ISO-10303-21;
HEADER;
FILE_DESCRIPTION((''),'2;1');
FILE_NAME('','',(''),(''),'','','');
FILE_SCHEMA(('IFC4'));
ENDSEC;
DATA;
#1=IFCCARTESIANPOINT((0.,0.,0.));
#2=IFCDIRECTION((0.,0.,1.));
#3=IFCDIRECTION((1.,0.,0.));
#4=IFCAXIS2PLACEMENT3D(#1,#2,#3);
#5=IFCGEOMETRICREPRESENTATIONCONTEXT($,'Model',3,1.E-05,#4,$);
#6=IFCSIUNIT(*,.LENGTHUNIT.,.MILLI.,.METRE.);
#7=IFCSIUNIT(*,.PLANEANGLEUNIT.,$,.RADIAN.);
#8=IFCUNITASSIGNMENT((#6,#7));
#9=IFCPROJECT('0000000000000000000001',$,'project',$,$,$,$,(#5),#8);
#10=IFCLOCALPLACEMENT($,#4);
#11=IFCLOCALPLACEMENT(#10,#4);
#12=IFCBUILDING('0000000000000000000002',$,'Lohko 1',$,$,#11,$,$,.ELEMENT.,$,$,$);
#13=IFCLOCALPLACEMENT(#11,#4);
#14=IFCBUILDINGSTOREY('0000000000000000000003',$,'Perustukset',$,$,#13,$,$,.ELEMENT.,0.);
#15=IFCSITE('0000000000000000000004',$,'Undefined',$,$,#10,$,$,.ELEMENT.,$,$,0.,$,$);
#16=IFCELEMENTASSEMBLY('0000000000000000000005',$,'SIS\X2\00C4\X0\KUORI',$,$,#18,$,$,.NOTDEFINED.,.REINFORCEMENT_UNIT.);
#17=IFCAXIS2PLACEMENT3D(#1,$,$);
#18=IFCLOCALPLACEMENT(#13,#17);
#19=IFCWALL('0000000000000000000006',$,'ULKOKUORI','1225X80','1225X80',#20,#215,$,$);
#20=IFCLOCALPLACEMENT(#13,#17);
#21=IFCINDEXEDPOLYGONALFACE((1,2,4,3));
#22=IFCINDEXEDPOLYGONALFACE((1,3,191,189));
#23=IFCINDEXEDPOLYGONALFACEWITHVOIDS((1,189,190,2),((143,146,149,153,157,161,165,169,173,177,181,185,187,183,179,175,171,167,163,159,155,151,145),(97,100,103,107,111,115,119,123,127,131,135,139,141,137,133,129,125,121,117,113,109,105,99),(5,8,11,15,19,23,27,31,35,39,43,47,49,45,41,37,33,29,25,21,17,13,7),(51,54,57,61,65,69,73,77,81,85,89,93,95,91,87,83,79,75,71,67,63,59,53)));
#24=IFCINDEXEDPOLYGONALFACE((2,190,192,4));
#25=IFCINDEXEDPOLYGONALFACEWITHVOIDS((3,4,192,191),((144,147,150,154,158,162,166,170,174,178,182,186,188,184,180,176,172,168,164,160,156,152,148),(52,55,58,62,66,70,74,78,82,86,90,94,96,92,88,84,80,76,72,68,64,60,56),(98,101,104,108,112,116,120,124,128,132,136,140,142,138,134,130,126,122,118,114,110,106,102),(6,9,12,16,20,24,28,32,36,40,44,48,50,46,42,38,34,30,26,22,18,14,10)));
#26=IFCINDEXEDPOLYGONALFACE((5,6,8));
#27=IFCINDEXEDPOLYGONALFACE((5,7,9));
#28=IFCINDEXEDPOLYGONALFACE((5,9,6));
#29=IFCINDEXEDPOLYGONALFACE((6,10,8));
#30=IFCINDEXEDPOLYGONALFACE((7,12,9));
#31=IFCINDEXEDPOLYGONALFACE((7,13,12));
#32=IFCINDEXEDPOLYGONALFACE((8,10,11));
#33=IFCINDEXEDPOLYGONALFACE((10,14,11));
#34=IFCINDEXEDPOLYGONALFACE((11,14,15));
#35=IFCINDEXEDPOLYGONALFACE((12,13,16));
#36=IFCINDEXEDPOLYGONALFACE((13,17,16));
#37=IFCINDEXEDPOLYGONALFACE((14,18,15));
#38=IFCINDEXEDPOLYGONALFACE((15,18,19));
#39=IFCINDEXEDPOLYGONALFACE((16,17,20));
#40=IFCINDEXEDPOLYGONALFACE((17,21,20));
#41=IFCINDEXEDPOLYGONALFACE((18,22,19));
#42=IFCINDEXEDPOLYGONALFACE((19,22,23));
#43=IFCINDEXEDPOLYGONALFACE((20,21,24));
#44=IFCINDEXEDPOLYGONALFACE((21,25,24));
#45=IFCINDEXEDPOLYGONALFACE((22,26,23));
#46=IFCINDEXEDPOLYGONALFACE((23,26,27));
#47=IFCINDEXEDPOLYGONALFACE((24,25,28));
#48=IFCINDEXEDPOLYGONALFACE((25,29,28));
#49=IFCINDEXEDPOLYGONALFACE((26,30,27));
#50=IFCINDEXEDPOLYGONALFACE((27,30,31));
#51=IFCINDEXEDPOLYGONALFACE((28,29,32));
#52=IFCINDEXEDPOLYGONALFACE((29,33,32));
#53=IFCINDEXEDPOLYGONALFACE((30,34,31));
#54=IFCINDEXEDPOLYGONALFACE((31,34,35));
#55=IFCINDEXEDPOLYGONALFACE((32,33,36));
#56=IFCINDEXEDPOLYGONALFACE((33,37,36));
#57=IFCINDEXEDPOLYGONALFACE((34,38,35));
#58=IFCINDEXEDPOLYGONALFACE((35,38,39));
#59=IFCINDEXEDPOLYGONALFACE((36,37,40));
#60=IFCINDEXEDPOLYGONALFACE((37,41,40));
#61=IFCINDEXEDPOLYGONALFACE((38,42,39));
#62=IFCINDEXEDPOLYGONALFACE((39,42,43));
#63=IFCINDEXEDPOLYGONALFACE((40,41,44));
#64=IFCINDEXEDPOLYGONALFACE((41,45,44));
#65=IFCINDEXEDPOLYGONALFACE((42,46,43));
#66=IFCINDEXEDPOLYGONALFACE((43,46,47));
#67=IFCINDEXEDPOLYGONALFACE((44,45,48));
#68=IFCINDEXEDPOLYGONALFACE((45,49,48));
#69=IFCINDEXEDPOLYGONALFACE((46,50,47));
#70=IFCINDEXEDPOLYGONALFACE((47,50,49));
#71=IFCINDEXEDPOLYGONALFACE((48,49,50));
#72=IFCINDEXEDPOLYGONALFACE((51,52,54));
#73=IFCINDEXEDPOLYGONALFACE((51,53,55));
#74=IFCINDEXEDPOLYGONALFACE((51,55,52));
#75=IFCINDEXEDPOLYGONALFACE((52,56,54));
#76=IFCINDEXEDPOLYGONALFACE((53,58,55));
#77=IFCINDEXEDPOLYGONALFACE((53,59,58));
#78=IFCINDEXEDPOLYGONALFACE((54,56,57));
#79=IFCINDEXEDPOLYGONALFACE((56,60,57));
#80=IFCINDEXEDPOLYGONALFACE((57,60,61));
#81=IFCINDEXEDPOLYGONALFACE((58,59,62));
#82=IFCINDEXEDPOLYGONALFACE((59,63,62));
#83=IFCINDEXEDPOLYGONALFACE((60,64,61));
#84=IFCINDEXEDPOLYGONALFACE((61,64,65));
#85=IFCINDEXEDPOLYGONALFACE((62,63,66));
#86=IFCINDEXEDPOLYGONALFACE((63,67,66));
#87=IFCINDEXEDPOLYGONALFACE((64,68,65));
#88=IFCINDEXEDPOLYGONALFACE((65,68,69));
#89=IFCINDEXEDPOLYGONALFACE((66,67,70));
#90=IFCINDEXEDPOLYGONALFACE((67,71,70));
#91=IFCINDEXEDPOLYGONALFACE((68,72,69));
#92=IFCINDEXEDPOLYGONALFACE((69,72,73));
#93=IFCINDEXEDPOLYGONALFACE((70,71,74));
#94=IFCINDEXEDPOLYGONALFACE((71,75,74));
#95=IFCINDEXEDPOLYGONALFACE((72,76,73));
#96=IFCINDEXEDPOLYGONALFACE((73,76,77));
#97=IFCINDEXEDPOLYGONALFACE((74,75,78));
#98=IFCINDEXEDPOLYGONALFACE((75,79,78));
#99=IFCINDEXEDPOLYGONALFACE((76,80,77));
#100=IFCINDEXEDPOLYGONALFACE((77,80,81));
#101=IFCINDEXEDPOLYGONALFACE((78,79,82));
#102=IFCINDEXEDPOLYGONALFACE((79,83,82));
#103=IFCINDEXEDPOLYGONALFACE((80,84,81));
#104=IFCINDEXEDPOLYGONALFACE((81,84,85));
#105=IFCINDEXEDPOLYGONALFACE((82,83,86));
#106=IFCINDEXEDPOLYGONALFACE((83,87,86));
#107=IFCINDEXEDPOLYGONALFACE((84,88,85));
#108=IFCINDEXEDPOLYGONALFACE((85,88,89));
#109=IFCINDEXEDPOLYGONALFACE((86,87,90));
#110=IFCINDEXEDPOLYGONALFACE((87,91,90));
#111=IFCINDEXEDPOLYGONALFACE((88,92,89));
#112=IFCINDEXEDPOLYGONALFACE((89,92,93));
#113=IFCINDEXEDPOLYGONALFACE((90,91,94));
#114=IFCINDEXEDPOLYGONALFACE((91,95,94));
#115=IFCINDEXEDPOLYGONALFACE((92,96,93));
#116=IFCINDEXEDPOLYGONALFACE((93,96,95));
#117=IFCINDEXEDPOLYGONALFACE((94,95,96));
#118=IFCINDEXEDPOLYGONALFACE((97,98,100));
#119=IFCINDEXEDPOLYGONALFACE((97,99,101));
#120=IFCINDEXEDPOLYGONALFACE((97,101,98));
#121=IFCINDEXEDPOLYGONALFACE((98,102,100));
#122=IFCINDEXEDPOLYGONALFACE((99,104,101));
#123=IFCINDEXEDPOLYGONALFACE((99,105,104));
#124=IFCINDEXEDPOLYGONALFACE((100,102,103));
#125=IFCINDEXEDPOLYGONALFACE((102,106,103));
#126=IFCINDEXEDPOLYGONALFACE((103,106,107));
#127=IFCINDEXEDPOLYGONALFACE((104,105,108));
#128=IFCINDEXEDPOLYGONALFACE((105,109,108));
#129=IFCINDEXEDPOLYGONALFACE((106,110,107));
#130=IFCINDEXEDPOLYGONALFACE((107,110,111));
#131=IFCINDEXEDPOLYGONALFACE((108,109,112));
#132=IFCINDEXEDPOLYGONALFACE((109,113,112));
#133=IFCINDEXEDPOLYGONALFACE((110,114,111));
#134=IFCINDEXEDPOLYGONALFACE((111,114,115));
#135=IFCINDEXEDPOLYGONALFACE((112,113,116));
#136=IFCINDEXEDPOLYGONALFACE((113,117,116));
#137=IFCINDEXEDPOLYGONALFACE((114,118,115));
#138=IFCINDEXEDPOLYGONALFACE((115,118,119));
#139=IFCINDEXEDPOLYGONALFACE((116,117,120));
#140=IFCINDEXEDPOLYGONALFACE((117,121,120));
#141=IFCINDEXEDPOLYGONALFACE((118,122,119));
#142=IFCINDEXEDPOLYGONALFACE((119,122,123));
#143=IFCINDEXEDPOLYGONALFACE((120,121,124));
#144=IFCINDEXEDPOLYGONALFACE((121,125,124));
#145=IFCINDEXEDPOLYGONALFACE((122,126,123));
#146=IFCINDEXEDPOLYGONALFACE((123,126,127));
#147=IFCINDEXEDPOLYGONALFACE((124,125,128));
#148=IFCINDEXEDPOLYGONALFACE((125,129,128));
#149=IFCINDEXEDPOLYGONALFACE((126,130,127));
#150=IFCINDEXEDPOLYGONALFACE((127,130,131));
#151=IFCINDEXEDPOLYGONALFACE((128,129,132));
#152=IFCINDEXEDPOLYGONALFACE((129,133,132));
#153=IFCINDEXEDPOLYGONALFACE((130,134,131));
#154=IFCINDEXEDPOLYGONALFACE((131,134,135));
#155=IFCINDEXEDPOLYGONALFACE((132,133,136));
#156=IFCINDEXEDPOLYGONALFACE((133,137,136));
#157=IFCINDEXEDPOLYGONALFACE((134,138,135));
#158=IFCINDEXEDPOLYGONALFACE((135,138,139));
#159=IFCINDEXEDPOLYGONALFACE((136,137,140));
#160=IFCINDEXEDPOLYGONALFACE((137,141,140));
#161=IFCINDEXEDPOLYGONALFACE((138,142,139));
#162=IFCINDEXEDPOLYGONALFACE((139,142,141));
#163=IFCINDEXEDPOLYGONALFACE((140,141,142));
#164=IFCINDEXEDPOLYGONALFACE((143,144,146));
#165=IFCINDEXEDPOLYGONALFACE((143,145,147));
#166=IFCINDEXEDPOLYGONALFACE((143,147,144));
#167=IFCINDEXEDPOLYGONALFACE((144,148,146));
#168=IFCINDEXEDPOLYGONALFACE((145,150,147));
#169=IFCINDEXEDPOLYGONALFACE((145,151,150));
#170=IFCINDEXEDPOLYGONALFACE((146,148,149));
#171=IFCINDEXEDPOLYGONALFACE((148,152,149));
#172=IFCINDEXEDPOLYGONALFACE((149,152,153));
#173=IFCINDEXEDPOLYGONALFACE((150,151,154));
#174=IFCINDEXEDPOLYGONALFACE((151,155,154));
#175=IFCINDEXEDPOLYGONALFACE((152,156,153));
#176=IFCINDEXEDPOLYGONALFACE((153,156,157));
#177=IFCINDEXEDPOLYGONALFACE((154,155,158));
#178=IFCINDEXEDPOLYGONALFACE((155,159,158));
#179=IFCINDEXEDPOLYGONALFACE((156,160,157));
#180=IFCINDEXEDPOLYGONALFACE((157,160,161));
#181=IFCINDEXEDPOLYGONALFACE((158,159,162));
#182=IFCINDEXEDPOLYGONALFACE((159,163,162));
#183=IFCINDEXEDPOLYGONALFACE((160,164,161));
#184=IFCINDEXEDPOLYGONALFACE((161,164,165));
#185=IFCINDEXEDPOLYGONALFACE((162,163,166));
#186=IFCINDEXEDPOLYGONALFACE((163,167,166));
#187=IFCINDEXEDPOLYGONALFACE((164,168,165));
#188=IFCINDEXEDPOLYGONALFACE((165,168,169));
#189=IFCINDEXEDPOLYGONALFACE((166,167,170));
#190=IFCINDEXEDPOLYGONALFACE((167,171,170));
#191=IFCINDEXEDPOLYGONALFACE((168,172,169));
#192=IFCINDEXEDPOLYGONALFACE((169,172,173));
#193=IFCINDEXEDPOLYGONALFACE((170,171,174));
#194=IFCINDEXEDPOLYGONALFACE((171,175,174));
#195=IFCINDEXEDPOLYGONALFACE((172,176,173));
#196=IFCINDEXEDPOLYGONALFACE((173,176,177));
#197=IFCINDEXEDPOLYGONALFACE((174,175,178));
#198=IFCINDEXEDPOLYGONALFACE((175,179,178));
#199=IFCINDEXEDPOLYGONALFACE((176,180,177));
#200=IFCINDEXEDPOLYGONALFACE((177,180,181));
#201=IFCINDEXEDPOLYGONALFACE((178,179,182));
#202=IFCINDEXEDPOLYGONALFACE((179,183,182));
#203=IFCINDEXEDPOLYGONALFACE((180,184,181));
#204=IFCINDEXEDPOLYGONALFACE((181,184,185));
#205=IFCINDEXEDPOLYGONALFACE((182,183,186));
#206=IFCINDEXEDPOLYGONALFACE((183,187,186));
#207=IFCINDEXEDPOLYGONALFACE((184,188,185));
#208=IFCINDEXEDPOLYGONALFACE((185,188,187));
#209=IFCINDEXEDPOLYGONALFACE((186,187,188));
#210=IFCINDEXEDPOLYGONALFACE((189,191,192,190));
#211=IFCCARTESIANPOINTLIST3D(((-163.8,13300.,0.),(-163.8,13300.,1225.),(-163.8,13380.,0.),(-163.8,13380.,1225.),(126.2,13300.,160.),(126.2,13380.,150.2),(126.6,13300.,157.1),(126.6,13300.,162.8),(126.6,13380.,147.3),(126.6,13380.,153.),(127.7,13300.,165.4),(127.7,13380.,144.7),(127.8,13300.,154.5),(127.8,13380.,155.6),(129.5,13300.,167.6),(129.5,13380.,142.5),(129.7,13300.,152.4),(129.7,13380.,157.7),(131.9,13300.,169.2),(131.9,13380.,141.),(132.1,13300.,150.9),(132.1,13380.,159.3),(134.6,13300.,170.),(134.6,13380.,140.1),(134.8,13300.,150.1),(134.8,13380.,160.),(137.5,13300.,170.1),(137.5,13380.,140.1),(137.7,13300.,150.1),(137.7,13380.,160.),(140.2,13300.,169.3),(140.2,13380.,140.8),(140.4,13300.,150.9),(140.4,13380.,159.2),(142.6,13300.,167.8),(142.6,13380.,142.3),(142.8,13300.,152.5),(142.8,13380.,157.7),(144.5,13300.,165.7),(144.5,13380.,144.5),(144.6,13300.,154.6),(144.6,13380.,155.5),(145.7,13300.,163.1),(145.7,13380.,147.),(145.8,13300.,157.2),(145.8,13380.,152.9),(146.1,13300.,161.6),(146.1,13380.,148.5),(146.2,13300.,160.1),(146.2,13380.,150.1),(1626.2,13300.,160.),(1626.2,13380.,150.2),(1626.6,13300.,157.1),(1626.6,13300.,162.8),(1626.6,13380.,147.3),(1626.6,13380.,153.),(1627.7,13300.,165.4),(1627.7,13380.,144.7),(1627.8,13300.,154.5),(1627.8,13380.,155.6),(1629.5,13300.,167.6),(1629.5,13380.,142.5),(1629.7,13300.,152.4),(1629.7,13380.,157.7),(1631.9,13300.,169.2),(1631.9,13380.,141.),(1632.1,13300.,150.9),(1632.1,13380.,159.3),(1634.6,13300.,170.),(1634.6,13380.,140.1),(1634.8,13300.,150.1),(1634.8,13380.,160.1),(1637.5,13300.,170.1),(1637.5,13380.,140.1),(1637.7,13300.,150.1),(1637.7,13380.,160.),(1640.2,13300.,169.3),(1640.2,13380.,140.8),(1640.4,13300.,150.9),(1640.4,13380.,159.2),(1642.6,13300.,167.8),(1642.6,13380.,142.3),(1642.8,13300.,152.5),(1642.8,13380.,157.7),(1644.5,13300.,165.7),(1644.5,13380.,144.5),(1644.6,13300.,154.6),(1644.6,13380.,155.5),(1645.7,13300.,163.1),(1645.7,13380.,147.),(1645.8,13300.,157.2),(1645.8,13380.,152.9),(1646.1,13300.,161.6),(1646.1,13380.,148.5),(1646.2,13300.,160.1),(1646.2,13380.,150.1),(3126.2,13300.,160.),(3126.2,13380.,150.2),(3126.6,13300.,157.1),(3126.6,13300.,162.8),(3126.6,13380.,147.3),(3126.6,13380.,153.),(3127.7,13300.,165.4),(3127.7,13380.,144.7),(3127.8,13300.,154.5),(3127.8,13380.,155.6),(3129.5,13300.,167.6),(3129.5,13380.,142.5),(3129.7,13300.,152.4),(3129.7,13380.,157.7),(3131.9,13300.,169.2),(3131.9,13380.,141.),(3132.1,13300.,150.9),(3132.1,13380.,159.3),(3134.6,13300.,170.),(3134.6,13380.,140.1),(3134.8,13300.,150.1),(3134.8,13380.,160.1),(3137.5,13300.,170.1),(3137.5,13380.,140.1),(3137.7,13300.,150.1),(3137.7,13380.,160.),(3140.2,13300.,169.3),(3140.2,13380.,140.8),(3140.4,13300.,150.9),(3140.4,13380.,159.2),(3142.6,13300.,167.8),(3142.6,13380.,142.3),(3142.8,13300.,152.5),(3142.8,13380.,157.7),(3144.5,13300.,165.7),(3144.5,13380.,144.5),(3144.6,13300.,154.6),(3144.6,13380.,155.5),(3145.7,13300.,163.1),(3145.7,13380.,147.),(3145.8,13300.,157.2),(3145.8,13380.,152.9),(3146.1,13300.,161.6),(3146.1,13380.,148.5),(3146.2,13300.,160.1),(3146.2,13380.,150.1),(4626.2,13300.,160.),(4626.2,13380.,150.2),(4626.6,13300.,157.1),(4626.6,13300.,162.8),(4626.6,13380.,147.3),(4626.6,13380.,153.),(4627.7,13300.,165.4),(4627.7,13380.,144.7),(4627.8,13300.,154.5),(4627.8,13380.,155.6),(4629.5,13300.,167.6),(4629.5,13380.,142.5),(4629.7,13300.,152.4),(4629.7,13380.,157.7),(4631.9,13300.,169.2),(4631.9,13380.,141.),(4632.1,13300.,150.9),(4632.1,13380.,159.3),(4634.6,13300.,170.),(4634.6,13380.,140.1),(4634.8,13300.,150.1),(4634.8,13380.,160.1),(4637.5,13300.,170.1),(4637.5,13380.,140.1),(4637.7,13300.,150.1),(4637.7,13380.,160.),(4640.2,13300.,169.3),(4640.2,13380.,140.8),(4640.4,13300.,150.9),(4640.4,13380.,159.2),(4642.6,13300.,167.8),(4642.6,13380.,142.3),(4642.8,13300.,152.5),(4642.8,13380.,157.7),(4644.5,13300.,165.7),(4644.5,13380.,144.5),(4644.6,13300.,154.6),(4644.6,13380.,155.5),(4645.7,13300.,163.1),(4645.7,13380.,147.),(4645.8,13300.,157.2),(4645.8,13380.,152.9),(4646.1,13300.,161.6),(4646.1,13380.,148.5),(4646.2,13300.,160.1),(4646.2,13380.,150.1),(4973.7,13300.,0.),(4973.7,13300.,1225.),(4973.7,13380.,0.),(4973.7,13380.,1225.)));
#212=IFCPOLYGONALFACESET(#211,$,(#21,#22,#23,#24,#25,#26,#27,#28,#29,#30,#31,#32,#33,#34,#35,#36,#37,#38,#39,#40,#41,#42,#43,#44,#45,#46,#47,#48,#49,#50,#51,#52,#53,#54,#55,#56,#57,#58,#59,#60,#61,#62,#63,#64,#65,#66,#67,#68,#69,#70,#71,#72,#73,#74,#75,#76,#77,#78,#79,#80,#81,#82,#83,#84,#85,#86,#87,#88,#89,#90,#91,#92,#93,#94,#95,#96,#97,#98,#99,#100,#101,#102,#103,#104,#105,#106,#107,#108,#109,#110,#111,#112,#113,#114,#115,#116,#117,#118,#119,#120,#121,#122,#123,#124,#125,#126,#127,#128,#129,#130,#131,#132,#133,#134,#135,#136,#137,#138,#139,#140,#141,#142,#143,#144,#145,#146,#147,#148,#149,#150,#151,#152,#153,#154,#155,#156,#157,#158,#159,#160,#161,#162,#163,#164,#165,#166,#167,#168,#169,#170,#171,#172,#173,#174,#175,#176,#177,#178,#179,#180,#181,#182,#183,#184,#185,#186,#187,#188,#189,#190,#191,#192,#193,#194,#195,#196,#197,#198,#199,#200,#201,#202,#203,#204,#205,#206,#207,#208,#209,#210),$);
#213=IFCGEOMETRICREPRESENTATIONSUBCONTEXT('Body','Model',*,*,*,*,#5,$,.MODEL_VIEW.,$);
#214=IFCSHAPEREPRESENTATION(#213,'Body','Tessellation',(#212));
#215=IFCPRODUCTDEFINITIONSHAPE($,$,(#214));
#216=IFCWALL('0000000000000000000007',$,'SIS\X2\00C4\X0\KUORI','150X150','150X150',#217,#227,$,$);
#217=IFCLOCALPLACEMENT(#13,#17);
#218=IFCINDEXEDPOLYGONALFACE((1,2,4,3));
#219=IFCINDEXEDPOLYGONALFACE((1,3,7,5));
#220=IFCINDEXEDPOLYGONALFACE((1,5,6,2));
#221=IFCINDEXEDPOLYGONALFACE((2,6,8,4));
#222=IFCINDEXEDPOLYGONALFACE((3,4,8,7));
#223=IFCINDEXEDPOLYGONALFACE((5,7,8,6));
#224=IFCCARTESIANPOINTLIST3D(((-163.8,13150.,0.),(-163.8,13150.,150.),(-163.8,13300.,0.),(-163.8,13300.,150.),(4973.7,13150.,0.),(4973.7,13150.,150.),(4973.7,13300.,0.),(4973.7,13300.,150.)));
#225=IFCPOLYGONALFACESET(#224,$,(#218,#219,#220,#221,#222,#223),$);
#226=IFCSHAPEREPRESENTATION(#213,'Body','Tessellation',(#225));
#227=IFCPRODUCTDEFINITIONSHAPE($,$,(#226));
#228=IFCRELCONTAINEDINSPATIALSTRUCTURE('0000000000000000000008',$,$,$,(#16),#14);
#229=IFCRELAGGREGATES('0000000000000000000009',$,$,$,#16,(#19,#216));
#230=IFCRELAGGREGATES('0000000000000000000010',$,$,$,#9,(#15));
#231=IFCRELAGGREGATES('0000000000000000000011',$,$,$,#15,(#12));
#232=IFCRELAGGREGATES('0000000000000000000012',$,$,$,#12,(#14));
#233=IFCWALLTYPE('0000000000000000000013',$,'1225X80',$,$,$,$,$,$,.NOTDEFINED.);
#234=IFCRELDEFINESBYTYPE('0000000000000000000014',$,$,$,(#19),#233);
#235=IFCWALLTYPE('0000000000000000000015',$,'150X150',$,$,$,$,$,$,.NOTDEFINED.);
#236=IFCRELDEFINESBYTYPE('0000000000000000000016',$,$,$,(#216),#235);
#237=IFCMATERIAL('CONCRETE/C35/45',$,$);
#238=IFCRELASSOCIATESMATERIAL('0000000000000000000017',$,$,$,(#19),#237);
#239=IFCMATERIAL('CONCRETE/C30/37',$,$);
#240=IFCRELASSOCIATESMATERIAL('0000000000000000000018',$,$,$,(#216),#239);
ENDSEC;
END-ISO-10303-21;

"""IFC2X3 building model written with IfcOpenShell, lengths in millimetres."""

from ifc_helpers import new_model, si_unit, frame, frame_2d, origin_with_axes, origin_2d_with_axis, place, context, subcontext, project, spatial, rectangle, circle, extrude, boolean, material, type_object, element, aggregate, save


model = new_model("IFC2X3")

# Units and contexts
model_context = context("Model", 3, precision=1e-05, world=origin_with_axes())
body_context = subcontext(model_context, "Body", "Model", "MODEL_VIEW")
ifc_project = project(units=[si_unit("LENGTHUNIT", "METRE", prefix="MILLI"), si_unit("PLANEANGLEUNIT", "RADIAN")], contexts=[model_context])

# Site, building, storey
site_placement = place(None, origin_with_axes())
site = spatial("IfcSite", under=ifc_project, at=site_placement, Name="Undefined", CompositionType="ELEMENT", RefElevation=0.0)
building_placement = place(site_placement, origin_with_axes())
building = spatial("IfcBuilding", under=site, at=building_placement, Name="Lohko 1", CompositionType="ELEMENT")
storey_placement = place(building_placement, origin_with_axes())
storey = spatial("IfcBuildingStorey", under=building, at=storey_placement, Name="Perustukset", CompositionType="ELEMENT", Elevation=0.0)

# Element assembly, walls
assembly_placement = place(storey_placement, origin_with_axes())
assembly = element("IfcElementAssembly", 1, at=assembly_placement, inside=storey, Name="SISÄKUORI", AssemblyPlace="NOTDEFINED", PredefinedType="REINFORCEMENT_UNIT")
ifc_material_1 = material(Name="CONCRETE/C35/45")
wall_type_1 = type_object("IfcWallType", Name="1225X80", PredefinedType="NOTDEFINED")
wall_1_placement = place(assembly_placement, frame((-163.8, 13340.0, 0.0), z_axis=(0.0, 0.0, 1.0), x_axis=(1.0, -0.000003, 0.0)))
wall_1 = element("IfcWall", 2, at=wall_1_placement, type_object=wall_type_1, material=ifc_material_1, Name="ULKOKUORI", Description="1225X80", ObjectType="1225X80", context=body_context, shape_type="CSG", body=[
    boolean("DIFFERENCE", boolean("DIFFERENCE", boolean("DIFFERENCE", boolean("DIFFERENCE", extrude(rectangle(XDim=5137.5, YDim=80.0, at=frame_2d((0.0, 2568.7), x_axis=(0.0, -1.0))), frame((0.0, 0.0, 0.0), z_axis=(0.0, 0.0, 1.0), x_axis=(0.0, -1.0, 0.0)), (0.0, 0.0, 1.0), 1225.0), extrude(circle(Radius=10.0, at=origin_2d_with_axis()), frame((300.0, 51.2, 148.7), z_axis=(0.000003, -0.992278, 0.124035), x_axis=(1.0, 0.000003, 0.0)), (0.0, 0.0, 1.0), 100.6)), extrude(circle(Radius=10.0, at=origin_2d_with_axis()), frame((1800.0, 51.2, 148.7), z_axis=(0.000003, -0.992278, 0.124035), x_axis=(1.0, 0.000003, 0.0)), (0.0, 0.0, 1.0), 100.6)), extrude(circle(Radius=10.0, at=origin_2d_with_axis()), frame((3300.0, 51.2, 148.7), z_axis=(0.000003, -0.992278, 0.124035), x_axis=(1.0, 0.000003, 0.0)), (0.0, 0.0, 1.0), 100.6)), extrude(circle(Radius=10.0, at=origin_2d_with_axis()), frame((4800.0, 51.2, 148.7), z_axis=(0.000003, -0.992278, 0.124035), x_axis=(1.0, 0.000003, 0.0)), (0.0, 0.0, 1.0), 100.6)),
])
ifc_material_2 = material(Name="CONCRETE/C30/37")
wall_type_2 = type_object("IfcWallType", Name="150X150", PredefinedType="NOTDEFINED")
wall_2_placement = place(assembly_placement, frame((-163.8, 13225.0, 0.0), z_axis=(0.0, 0.0, 1.0), x_axis=(1.0, -0.000003, 0.0)))
wall_2 = element("IfcWall", 3, at=wall_2_placement, type_object=wall_type_2, material=ifc_material_2, Name="SISÄKUORI", Description="150X150", ObjectType="150X150", context=body_context, shape_type="SweptSolid", body=[
    extrude(rectangle(XDim=5137.5, YDim=150.0, at=frame_2d((0.0, 2568.7), x_axis=(0.0, -1.0))), frame((0.0, 0.0, 0.0), z_axis=(0.0, 0.0, 1.0), x_axis=(0.0, -1.0, 0.0)), (0.0, 0.0, 1.0), 150.0),
])
aggregate(assembly, [wall_1, wall_2])

save(model, "model.ifc")
